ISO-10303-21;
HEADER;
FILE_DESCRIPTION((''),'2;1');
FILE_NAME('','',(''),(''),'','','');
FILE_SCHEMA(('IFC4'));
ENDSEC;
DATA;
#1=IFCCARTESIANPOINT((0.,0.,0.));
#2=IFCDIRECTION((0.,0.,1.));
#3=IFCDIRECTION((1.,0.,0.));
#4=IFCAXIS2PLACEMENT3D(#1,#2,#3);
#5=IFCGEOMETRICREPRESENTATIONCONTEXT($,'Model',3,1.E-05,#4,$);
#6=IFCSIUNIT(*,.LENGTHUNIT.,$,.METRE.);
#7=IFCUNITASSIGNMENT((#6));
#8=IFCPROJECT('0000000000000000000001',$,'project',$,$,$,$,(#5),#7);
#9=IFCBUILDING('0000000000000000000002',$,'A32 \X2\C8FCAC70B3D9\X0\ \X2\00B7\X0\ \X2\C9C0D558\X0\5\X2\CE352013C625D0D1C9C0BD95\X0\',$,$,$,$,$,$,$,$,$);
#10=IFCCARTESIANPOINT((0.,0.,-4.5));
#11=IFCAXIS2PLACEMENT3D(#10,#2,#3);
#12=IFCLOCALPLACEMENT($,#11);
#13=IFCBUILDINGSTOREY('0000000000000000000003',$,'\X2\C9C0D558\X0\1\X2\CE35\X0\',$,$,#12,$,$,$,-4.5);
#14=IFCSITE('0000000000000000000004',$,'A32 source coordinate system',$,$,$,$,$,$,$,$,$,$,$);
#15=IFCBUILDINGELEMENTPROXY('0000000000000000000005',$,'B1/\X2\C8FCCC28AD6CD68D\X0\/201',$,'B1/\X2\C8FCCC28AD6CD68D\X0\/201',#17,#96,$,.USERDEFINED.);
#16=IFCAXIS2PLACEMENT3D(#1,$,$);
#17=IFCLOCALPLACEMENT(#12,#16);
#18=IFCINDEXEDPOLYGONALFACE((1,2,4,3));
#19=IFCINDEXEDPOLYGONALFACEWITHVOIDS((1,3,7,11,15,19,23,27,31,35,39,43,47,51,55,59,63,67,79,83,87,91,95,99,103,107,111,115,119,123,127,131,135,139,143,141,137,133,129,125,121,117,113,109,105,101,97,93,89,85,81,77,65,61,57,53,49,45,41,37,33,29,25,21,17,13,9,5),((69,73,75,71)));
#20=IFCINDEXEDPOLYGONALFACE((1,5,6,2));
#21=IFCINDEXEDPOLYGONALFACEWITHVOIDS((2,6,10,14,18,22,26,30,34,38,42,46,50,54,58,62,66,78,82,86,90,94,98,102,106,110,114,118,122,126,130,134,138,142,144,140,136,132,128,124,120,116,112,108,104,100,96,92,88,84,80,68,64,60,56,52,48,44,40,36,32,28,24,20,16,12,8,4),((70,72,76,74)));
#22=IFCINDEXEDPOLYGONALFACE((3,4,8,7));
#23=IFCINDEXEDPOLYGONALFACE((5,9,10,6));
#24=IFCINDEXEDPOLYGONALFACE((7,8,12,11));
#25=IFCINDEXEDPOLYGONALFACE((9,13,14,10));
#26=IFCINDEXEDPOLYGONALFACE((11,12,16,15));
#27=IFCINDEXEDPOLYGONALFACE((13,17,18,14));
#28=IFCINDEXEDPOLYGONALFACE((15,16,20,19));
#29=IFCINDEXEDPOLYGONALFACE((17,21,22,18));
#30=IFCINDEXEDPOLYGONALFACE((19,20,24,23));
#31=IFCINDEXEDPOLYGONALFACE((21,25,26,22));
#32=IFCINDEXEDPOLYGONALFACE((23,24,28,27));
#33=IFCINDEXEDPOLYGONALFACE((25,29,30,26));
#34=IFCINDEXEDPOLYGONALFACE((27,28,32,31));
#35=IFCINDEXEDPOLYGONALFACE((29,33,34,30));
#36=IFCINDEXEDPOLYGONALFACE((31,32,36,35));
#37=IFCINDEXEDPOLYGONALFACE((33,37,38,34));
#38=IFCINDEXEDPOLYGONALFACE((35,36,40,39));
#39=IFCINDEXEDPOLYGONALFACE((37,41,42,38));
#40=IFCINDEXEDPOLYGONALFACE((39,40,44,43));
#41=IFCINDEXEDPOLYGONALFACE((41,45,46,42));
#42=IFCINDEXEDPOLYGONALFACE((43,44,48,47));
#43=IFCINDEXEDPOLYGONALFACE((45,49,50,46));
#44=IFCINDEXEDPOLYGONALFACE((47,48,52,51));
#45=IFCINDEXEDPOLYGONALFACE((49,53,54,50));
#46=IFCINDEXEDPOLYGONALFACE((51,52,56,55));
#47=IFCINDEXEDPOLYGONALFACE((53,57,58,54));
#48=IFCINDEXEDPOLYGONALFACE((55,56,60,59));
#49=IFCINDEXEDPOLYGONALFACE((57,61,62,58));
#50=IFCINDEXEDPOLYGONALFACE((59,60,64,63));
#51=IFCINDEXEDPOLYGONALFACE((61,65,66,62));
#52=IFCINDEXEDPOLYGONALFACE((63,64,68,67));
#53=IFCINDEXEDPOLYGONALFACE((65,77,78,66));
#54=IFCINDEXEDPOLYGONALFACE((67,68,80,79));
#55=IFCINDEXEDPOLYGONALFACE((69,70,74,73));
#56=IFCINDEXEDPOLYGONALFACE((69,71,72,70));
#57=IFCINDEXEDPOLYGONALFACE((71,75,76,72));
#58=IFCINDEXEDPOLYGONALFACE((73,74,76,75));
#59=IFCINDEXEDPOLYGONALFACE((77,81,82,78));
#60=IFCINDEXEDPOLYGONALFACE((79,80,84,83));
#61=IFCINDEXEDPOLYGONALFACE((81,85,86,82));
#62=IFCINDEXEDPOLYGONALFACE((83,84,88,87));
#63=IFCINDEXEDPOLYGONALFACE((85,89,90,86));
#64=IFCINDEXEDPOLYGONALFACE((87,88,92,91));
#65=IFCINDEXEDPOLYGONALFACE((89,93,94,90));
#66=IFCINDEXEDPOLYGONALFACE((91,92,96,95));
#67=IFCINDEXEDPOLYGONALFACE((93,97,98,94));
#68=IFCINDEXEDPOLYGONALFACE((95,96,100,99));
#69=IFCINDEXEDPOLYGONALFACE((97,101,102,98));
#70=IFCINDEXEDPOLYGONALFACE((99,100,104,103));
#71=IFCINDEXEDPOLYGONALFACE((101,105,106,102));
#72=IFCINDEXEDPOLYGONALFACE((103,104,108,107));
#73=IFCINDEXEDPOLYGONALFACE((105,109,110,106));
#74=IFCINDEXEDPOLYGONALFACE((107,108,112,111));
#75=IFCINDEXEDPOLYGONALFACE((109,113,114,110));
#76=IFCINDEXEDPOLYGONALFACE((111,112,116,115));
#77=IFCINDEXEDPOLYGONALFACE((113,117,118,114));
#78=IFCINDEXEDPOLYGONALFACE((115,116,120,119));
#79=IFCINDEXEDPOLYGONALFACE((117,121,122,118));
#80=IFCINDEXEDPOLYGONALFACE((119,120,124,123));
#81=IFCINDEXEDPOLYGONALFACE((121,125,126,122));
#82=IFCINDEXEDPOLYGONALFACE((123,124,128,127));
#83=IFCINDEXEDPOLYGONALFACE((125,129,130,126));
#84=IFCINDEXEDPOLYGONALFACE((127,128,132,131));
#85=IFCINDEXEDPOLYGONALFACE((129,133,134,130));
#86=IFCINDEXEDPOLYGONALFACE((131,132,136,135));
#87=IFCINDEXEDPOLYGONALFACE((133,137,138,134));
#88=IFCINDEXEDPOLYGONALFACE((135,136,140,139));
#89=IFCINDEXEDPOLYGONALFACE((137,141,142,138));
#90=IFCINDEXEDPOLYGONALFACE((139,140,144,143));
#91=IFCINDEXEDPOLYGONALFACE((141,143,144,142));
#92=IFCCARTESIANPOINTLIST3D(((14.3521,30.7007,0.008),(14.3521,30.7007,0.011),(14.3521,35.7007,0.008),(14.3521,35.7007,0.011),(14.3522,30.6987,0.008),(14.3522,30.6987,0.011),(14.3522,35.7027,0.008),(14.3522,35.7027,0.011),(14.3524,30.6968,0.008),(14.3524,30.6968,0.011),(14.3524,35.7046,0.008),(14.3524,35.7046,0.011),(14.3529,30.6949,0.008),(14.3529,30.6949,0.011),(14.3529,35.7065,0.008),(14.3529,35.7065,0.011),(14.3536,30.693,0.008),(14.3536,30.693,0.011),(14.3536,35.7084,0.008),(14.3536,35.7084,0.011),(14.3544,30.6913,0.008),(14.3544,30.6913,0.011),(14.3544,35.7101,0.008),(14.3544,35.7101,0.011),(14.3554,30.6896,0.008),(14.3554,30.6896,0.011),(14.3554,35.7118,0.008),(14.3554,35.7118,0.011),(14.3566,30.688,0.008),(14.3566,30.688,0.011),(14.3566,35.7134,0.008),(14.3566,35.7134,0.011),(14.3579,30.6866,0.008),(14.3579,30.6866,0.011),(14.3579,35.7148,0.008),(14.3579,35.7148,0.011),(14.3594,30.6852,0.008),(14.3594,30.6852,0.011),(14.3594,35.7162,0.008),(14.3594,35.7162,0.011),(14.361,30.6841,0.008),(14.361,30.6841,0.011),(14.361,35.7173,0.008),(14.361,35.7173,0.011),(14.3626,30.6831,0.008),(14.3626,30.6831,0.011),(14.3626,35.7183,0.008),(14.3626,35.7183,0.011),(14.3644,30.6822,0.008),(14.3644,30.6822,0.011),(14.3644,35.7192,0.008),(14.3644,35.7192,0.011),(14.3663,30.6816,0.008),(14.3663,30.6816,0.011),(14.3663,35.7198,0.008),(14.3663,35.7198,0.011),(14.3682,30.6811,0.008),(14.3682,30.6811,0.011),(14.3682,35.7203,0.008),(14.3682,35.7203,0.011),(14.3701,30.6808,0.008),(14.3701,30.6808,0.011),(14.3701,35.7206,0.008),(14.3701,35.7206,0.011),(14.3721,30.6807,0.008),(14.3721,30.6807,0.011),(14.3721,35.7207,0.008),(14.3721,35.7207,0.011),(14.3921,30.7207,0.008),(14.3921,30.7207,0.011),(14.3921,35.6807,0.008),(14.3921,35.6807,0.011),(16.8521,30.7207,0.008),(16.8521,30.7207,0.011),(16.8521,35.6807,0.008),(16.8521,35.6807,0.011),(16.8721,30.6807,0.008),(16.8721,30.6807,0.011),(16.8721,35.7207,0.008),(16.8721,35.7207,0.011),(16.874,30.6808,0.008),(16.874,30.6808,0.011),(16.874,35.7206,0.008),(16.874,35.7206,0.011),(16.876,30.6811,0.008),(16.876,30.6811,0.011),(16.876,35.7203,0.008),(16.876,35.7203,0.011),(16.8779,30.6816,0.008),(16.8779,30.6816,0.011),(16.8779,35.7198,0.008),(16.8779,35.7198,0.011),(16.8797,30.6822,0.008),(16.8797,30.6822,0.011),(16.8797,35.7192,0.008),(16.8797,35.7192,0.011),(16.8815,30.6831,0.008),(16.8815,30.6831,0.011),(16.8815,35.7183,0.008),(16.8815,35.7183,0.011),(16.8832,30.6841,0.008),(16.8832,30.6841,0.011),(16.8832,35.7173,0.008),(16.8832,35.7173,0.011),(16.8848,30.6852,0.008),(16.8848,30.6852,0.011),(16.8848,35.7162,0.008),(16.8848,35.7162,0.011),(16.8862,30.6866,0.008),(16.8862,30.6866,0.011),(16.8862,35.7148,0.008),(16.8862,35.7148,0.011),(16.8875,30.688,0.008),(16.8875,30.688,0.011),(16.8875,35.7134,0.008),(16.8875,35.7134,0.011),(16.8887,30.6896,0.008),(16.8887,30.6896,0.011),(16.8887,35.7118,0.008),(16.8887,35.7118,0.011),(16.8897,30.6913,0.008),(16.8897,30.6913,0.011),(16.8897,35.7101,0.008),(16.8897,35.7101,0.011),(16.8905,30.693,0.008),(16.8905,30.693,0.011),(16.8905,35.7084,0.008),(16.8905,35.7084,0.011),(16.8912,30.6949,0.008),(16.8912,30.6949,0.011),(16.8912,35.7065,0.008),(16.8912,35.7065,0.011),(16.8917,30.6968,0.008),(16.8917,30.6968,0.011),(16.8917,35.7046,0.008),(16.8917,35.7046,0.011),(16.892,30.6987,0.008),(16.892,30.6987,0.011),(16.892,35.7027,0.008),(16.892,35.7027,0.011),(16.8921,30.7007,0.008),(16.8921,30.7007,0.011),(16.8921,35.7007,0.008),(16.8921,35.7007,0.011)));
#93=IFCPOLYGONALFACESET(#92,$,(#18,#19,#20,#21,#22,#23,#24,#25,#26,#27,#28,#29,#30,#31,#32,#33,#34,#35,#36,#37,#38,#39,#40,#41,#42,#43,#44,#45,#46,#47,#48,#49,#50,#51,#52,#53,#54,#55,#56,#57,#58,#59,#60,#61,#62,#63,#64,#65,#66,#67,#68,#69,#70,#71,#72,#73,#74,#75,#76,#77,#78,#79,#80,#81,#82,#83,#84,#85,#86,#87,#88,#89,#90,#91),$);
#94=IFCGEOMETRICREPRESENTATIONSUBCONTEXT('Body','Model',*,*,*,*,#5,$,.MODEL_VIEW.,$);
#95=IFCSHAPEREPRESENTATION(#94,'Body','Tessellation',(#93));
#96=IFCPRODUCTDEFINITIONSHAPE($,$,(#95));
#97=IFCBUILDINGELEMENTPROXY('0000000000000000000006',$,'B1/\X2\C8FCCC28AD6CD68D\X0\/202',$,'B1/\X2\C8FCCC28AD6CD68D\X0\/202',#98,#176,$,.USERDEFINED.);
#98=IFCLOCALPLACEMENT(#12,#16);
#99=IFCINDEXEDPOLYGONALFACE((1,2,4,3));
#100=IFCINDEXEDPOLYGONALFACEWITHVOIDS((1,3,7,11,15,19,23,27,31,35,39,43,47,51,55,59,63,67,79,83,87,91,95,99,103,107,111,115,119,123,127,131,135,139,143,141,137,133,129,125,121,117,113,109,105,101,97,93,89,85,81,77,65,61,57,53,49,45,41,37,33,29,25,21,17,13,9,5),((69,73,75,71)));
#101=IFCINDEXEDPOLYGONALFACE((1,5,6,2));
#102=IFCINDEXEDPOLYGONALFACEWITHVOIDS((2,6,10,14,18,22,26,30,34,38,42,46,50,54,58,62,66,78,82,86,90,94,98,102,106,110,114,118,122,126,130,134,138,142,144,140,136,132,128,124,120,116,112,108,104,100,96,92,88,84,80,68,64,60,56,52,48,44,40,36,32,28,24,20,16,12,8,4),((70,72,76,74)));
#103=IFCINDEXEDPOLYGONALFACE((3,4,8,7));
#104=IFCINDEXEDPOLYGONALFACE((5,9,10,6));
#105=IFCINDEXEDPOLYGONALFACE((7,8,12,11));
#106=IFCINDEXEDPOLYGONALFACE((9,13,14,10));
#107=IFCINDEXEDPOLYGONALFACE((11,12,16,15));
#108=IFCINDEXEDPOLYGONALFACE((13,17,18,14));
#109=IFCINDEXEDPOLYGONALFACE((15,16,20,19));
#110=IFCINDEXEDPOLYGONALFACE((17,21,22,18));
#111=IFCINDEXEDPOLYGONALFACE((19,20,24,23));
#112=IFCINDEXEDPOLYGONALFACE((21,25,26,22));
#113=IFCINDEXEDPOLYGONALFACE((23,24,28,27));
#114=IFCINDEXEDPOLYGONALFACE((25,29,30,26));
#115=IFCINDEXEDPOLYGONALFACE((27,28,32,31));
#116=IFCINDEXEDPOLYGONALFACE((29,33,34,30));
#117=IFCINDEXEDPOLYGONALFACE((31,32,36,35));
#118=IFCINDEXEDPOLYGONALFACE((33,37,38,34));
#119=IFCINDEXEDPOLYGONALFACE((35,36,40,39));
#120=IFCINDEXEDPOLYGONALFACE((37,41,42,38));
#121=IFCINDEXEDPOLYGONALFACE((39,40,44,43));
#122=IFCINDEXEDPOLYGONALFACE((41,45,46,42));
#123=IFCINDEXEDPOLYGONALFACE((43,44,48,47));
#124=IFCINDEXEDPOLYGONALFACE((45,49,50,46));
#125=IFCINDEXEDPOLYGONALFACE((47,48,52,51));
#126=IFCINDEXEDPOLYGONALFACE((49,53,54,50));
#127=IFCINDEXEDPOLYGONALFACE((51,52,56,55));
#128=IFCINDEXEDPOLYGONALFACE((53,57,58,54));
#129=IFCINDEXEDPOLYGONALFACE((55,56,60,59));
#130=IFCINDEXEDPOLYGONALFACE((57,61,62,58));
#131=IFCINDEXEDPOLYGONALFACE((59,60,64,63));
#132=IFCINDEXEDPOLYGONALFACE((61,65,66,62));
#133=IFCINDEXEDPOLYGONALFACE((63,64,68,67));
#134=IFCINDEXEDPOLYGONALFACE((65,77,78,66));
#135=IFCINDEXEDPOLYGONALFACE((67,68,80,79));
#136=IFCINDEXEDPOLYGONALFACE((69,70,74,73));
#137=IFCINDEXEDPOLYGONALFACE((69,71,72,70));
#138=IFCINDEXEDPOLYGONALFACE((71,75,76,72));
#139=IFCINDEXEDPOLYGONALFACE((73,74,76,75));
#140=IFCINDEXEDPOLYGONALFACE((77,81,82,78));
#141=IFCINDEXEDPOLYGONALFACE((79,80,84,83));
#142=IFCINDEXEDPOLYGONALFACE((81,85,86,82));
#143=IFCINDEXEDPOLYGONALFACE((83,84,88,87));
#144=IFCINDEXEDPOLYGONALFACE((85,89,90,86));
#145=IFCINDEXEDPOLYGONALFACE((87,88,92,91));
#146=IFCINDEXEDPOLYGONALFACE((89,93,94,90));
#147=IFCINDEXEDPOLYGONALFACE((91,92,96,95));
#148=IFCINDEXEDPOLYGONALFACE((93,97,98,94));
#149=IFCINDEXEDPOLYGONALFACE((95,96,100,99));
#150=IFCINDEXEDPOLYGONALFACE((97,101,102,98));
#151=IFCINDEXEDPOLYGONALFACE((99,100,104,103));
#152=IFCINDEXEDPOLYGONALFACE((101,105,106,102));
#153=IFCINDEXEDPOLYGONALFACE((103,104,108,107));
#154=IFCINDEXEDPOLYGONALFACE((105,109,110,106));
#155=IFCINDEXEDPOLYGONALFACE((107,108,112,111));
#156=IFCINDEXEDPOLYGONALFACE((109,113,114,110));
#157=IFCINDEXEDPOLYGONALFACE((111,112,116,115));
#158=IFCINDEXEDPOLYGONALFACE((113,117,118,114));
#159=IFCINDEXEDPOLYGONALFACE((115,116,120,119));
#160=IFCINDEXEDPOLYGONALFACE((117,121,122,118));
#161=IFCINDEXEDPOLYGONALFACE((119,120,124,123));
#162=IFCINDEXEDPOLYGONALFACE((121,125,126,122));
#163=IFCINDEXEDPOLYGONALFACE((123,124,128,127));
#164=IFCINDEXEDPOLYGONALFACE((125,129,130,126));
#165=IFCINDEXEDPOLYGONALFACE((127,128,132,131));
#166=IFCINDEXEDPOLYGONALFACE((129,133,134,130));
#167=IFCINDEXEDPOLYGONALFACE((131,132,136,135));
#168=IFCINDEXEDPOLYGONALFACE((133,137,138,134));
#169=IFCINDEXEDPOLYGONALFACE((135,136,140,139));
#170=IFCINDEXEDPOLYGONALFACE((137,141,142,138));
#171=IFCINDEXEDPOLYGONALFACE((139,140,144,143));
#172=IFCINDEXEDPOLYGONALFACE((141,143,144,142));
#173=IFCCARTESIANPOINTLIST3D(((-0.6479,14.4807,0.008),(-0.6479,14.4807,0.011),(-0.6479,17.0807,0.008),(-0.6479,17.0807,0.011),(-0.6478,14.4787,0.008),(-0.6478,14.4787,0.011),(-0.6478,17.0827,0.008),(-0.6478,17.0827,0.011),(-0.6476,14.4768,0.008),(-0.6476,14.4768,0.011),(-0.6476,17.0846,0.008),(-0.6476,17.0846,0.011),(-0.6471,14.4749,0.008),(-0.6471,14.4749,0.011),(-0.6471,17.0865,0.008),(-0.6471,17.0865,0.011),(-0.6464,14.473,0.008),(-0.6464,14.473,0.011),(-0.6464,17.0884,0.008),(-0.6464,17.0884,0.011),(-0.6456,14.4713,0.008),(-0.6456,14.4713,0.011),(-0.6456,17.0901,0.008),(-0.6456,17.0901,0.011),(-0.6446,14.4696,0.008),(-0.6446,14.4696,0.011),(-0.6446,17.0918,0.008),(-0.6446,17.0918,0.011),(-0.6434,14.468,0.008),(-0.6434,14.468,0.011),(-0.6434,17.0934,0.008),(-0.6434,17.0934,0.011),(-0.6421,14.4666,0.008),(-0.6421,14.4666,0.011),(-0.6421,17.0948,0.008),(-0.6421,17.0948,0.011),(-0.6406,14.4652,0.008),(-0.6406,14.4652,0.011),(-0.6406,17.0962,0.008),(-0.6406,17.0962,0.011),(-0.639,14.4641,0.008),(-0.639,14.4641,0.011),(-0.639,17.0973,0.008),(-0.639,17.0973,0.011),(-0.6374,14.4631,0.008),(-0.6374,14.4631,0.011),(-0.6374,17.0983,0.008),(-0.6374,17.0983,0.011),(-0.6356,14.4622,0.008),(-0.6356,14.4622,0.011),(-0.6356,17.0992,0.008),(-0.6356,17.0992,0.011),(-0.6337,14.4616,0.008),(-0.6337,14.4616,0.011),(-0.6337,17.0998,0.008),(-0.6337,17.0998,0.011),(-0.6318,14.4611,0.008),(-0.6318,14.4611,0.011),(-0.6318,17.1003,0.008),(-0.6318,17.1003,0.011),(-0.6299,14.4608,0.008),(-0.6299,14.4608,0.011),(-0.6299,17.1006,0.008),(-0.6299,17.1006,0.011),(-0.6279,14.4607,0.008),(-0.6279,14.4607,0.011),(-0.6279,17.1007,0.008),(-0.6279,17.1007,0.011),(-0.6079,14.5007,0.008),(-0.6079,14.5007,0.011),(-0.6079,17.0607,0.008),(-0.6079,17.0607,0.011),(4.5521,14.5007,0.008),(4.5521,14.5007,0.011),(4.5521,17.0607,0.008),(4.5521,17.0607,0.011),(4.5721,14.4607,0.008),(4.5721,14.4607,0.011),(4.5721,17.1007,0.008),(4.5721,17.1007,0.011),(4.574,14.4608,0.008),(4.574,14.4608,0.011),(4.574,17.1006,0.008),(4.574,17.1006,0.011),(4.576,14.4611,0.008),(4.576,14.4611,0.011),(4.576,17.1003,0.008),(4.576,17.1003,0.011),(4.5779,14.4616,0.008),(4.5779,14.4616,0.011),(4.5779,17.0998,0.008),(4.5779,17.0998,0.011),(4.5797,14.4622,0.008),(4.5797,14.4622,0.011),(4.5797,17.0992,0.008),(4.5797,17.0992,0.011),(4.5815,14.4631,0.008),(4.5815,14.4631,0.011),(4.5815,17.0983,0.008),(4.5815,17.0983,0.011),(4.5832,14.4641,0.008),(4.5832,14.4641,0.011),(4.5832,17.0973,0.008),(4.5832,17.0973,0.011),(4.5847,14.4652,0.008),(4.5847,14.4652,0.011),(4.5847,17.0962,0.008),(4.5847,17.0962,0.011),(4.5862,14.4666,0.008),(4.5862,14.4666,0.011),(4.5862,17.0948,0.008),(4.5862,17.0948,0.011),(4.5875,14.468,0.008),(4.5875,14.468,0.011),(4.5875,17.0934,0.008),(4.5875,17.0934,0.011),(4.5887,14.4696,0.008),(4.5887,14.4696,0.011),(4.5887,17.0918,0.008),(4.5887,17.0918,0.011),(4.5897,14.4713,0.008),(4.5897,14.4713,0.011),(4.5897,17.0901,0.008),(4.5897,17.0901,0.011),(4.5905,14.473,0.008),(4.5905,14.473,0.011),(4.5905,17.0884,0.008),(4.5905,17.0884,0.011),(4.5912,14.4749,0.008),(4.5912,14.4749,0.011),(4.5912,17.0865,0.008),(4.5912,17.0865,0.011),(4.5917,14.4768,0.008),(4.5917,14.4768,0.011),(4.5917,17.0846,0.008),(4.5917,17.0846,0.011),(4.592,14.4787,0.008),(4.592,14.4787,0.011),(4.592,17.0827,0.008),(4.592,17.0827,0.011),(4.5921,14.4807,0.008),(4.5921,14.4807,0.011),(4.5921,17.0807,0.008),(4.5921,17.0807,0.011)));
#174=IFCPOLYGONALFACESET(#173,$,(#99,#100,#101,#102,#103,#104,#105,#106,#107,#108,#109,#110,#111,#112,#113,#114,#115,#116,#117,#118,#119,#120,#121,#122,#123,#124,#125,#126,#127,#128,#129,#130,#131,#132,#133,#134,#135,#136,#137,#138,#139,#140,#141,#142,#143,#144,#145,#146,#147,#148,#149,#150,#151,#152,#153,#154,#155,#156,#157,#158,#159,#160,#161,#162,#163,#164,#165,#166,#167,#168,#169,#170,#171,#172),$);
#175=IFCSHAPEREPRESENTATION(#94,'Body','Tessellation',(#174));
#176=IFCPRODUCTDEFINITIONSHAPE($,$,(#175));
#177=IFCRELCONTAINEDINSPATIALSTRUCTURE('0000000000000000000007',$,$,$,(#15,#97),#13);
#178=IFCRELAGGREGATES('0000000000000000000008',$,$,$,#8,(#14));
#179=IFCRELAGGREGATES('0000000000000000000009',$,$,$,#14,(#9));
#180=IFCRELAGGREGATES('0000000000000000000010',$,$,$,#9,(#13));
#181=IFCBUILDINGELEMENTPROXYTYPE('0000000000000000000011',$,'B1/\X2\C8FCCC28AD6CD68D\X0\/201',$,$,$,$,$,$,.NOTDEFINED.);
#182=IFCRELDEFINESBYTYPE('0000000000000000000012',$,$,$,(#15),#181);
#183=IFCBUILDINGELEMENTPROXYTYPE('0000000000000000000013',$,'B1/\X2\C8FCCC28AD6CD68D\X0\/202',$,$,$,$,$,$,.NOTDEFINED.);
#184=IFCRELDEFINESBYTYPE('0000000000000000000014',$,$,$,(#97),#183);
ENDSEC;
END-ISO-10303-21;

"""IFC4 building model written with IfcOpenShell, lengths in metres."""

from ifc_helpers import new_model, si_unit, frame, origin, origin_with_axes, place, context, subcontext, project, spatial, polyline, outline, extrude, source, transform, mapped, type_object, type_shapes, element, save


model = new_model("IFC4")

# Units and contexts
model_context = context("Model", 3, precision=1e-05, world=origin_with_axes())
body_context = subcontext(model_context, "Body", "Model", "MODEL_VIEW")
ifc_project = project(units=[si_unit("LENGTHUNIT", "METRE")], contexts=[model_context])

# Site, building, storey
site = spatial("IfcSite", under=ifc_project, Name="A32 source coordinate system")
building = spatial("IfcBuilding", under=site, Name="A32 주거동 · 지하5층–옥탑지붕")
storey_placement = place(None, frame((0.0, 0.0, -4.5), z_axis=(0.0, 0.0, 1.0), x_axis=(1.0, 0.0, 0.0)))
storey = spatial("IfcBuildingStorey", under=building, at=storey_placement, Name="지하1층", Elevation=-4.5)

# Building element proxies
building_element_proxy_type_1 = type_object("IfcBuildingElementProxyType", Name="B1/주차구획/201", PredefinedType="NOTDEFINED")
shared_shape_1 = source(origin(), body_context, "Body", "SweptSolid", [
    extrude(outline(polyline([(14.3521, 35.7007), (14.3522, 35.7027), (14.3524, 35.7046), (14.3529, 35.7065), (14.3536, 35.7084), (14.3544, 35.7101), (14.3554, 35.7118), (14.3566, 35.7134), (14.3579, 35.7148), (14.3594, 35.7162), (14.361, 35.7173), (14.3626, 35.7183), (14.3644, 35.7192), (14.3663, 35.7198), (14.3682, 35.7203), (14.3701, 35.7206), (14.3721, 35.7207), (16.8721, 35.7207), (16.874, 35.7206), (16.876, 35.7203), (16.8779, 35.7198), (16.8797, 35.7192), (16.8815, 35.7183), (16.8832, 35.7173), (16.8848, 35.7162), (16.8862, 35.7148), (16.8875, 35.7134), (16.8887, 35.7118), (16.8897, 35.7101), (16.8905, 35.7084), (16.8912, 35.7065), (16.8917, 35.7046), (16.892, 35.7027), (16.8921, 35.7007), (16.8921, 30.7007), (16.892, 30.6987), (16.8917, 30.6968), (16.8912, 30.6949), (16.8905, 30.693), (16.8897, 30.6913), (16.8887, 30.6896), (16.8875, 30.688), (16.8862, 30.6866), (16.8848, 30.6852), (16.8832, 30.6841), (16.8815, 30.6831), (16.8797, 30.6822), (16.8779, 30.6816), (16.876, 30.6811), (16.874, 30.6808), (16.8721, 30.6807), (14.3721, 30.6807), (14.3701, 30.6808), (14.3682, 30.6811), (14.3663, 30.6816), (14.3644, 30.6822), (14.3626, 30.6831), (14.361, 30.6841), (14.3594, 30.6852), (14.3579, 30.6866), (14.3566, 30.688), (14.3554, 30.6896), (14.3544, 30.6913), (14.3536, 30.693), (14.3529, 30.6949), (14.3524, 30.6968), (14.3522, 30.6987), (14.3521, 30.7007), (14.3521, 35.7007)]), holes=[polyline([(14.3921, 35.6807), (14.3921, 30.7207), (16.8521, 30.7207), (16.8521, 35.6807), (14.3921, 35.6807)])]), frame((0.0, 0.0, 0.008)), (0.0, 0.0, 1.0), 0.003),
])
type_shapes(building_element_proxy_type_1, [shared_shape_1])
proxy_1_placement = place(storey_placement, origin_with_axes())
element("IfcBuildingElementProxy", 1, at=proxy_1_placement, inside=storey, type_object=building_element_proxy_type_1, Name="B1/주차구획/201", ObjectType="B1/주차구획/201", PredefinedType="USERDEFINED", context=body_context, shape_type="MappedRepresentation", body=[
    mapped(shared_shape_1, transform((0.0, 0.0, 0.0), scale=1.0)),
])
building_element_proxy_type_2 = type_object("IfcBuildingElementProxyType", Name="B1/주차구획/202", PredefinedType="NOTDEFINED")
shared_shape_2 = source(origin(), body_context, "Body", "SweptSolid", [
    extrude(outline(polyline([(-0.6279, 14.4607), (-0.6299, 14.4608), (-0.6318, 14.4611), (-0.6337, 14.4616), (-0.6356, 14.4622), (-0.6374, 14.4631), (-0.639, 14.4641), (-0.6406, 14.4652), (-0.6421, 14.4666), (-0.6434, 14.468), (-0.6446, 14.4696), (-0.6456, 14.4713), (-0.6464, 14.473), (-0.6471, 14.4749), (-0.6476, 14.4768), (-0.6478, 14.4787), (-0.6479, 14.4807), (-0.6479, 17.0807), (-0.6478, 17.0827), (-0.6476, 17.0846), (-0.6471, 17.0865), (-0.6464, 17.0884), (-0.6456, 17.0901), (-0.6446, 17.0918), (-0.6434, 17.0934), (-0.6421, 17.0948), (-0.6406, 17.0962), (-0.639, 17.0973), (-0.6374, 17.0983), (-0.6356, 17.0992), (-0.6337, 17.0998), (-0.6318, 17.1003), (-0.6299, 17.1006), (-0.6279, 17.1007), (4.5721, 17.1007), (4.574, 17.1006), (4.576, 17.1003), (4.5779, 17.0998), (4.5797, 17.0992), (4.5815, 17.0983), (4.5832, 17.0973), (4.5847, 17.0962), (4.5862, 17.0948), (4.5875, 17.0934), (4.5887, 17.0918), (4.5897, 17.0901), (4.5905, 17.0884), (4.5912, 17.0865), (4.5917, 17.0846), (4.592, 17.0827), (4.5921, 17.0807), (4.5921, 14.4807), (4.592, 14.4787), (4.5917, 14.4768), (4.5912, 14.4749), (4.5905, 14.473), (4.5897, 14.4713), (4.5887, 14.4696), (4.5875, 14.468), (4.5862, 14.4666), (4.5847, 14.4652), (4.5832, 14.4641), (4.5815, 14.4631), (4.5797, 14.4622), (4.5779, 14.4616), (4.576, 14.4611), (4.574, 14.4608), (4.5721, 14.4607), (-0.6279, 14.4607)]), holes=[polyline([(-0.6079, 14.5007), (4.5521, 14.5007), (4.5521, 17.0607), (-0.6079, 17.0607), (-0.6079, 14.5007)])]), frame((0.0, 0.0, 0.008)), (0.0, 0.0, 1.0), 0.003),
])
type_shapes(building_element_proxy_type_2, [shared_shape_2])
proxy_2_placement = place(storey_placement, origin_with_axes())
element("IfcBuildingElementProxy", 2, at=proxy_2_placement, inside=storey, type_object=building_element_proxy_type_2, Name="B1/주차구획/202", ObjectType="B1/주차구획/202", PredefinedType="USERDEFINED", context=body_context, shape_type="MappedRepresentation", body=[
    mapped(shared_shape_2, transform((0.0, 0.0, 0.0), scale=1.0)),
])

save(model, "model.ifc")
